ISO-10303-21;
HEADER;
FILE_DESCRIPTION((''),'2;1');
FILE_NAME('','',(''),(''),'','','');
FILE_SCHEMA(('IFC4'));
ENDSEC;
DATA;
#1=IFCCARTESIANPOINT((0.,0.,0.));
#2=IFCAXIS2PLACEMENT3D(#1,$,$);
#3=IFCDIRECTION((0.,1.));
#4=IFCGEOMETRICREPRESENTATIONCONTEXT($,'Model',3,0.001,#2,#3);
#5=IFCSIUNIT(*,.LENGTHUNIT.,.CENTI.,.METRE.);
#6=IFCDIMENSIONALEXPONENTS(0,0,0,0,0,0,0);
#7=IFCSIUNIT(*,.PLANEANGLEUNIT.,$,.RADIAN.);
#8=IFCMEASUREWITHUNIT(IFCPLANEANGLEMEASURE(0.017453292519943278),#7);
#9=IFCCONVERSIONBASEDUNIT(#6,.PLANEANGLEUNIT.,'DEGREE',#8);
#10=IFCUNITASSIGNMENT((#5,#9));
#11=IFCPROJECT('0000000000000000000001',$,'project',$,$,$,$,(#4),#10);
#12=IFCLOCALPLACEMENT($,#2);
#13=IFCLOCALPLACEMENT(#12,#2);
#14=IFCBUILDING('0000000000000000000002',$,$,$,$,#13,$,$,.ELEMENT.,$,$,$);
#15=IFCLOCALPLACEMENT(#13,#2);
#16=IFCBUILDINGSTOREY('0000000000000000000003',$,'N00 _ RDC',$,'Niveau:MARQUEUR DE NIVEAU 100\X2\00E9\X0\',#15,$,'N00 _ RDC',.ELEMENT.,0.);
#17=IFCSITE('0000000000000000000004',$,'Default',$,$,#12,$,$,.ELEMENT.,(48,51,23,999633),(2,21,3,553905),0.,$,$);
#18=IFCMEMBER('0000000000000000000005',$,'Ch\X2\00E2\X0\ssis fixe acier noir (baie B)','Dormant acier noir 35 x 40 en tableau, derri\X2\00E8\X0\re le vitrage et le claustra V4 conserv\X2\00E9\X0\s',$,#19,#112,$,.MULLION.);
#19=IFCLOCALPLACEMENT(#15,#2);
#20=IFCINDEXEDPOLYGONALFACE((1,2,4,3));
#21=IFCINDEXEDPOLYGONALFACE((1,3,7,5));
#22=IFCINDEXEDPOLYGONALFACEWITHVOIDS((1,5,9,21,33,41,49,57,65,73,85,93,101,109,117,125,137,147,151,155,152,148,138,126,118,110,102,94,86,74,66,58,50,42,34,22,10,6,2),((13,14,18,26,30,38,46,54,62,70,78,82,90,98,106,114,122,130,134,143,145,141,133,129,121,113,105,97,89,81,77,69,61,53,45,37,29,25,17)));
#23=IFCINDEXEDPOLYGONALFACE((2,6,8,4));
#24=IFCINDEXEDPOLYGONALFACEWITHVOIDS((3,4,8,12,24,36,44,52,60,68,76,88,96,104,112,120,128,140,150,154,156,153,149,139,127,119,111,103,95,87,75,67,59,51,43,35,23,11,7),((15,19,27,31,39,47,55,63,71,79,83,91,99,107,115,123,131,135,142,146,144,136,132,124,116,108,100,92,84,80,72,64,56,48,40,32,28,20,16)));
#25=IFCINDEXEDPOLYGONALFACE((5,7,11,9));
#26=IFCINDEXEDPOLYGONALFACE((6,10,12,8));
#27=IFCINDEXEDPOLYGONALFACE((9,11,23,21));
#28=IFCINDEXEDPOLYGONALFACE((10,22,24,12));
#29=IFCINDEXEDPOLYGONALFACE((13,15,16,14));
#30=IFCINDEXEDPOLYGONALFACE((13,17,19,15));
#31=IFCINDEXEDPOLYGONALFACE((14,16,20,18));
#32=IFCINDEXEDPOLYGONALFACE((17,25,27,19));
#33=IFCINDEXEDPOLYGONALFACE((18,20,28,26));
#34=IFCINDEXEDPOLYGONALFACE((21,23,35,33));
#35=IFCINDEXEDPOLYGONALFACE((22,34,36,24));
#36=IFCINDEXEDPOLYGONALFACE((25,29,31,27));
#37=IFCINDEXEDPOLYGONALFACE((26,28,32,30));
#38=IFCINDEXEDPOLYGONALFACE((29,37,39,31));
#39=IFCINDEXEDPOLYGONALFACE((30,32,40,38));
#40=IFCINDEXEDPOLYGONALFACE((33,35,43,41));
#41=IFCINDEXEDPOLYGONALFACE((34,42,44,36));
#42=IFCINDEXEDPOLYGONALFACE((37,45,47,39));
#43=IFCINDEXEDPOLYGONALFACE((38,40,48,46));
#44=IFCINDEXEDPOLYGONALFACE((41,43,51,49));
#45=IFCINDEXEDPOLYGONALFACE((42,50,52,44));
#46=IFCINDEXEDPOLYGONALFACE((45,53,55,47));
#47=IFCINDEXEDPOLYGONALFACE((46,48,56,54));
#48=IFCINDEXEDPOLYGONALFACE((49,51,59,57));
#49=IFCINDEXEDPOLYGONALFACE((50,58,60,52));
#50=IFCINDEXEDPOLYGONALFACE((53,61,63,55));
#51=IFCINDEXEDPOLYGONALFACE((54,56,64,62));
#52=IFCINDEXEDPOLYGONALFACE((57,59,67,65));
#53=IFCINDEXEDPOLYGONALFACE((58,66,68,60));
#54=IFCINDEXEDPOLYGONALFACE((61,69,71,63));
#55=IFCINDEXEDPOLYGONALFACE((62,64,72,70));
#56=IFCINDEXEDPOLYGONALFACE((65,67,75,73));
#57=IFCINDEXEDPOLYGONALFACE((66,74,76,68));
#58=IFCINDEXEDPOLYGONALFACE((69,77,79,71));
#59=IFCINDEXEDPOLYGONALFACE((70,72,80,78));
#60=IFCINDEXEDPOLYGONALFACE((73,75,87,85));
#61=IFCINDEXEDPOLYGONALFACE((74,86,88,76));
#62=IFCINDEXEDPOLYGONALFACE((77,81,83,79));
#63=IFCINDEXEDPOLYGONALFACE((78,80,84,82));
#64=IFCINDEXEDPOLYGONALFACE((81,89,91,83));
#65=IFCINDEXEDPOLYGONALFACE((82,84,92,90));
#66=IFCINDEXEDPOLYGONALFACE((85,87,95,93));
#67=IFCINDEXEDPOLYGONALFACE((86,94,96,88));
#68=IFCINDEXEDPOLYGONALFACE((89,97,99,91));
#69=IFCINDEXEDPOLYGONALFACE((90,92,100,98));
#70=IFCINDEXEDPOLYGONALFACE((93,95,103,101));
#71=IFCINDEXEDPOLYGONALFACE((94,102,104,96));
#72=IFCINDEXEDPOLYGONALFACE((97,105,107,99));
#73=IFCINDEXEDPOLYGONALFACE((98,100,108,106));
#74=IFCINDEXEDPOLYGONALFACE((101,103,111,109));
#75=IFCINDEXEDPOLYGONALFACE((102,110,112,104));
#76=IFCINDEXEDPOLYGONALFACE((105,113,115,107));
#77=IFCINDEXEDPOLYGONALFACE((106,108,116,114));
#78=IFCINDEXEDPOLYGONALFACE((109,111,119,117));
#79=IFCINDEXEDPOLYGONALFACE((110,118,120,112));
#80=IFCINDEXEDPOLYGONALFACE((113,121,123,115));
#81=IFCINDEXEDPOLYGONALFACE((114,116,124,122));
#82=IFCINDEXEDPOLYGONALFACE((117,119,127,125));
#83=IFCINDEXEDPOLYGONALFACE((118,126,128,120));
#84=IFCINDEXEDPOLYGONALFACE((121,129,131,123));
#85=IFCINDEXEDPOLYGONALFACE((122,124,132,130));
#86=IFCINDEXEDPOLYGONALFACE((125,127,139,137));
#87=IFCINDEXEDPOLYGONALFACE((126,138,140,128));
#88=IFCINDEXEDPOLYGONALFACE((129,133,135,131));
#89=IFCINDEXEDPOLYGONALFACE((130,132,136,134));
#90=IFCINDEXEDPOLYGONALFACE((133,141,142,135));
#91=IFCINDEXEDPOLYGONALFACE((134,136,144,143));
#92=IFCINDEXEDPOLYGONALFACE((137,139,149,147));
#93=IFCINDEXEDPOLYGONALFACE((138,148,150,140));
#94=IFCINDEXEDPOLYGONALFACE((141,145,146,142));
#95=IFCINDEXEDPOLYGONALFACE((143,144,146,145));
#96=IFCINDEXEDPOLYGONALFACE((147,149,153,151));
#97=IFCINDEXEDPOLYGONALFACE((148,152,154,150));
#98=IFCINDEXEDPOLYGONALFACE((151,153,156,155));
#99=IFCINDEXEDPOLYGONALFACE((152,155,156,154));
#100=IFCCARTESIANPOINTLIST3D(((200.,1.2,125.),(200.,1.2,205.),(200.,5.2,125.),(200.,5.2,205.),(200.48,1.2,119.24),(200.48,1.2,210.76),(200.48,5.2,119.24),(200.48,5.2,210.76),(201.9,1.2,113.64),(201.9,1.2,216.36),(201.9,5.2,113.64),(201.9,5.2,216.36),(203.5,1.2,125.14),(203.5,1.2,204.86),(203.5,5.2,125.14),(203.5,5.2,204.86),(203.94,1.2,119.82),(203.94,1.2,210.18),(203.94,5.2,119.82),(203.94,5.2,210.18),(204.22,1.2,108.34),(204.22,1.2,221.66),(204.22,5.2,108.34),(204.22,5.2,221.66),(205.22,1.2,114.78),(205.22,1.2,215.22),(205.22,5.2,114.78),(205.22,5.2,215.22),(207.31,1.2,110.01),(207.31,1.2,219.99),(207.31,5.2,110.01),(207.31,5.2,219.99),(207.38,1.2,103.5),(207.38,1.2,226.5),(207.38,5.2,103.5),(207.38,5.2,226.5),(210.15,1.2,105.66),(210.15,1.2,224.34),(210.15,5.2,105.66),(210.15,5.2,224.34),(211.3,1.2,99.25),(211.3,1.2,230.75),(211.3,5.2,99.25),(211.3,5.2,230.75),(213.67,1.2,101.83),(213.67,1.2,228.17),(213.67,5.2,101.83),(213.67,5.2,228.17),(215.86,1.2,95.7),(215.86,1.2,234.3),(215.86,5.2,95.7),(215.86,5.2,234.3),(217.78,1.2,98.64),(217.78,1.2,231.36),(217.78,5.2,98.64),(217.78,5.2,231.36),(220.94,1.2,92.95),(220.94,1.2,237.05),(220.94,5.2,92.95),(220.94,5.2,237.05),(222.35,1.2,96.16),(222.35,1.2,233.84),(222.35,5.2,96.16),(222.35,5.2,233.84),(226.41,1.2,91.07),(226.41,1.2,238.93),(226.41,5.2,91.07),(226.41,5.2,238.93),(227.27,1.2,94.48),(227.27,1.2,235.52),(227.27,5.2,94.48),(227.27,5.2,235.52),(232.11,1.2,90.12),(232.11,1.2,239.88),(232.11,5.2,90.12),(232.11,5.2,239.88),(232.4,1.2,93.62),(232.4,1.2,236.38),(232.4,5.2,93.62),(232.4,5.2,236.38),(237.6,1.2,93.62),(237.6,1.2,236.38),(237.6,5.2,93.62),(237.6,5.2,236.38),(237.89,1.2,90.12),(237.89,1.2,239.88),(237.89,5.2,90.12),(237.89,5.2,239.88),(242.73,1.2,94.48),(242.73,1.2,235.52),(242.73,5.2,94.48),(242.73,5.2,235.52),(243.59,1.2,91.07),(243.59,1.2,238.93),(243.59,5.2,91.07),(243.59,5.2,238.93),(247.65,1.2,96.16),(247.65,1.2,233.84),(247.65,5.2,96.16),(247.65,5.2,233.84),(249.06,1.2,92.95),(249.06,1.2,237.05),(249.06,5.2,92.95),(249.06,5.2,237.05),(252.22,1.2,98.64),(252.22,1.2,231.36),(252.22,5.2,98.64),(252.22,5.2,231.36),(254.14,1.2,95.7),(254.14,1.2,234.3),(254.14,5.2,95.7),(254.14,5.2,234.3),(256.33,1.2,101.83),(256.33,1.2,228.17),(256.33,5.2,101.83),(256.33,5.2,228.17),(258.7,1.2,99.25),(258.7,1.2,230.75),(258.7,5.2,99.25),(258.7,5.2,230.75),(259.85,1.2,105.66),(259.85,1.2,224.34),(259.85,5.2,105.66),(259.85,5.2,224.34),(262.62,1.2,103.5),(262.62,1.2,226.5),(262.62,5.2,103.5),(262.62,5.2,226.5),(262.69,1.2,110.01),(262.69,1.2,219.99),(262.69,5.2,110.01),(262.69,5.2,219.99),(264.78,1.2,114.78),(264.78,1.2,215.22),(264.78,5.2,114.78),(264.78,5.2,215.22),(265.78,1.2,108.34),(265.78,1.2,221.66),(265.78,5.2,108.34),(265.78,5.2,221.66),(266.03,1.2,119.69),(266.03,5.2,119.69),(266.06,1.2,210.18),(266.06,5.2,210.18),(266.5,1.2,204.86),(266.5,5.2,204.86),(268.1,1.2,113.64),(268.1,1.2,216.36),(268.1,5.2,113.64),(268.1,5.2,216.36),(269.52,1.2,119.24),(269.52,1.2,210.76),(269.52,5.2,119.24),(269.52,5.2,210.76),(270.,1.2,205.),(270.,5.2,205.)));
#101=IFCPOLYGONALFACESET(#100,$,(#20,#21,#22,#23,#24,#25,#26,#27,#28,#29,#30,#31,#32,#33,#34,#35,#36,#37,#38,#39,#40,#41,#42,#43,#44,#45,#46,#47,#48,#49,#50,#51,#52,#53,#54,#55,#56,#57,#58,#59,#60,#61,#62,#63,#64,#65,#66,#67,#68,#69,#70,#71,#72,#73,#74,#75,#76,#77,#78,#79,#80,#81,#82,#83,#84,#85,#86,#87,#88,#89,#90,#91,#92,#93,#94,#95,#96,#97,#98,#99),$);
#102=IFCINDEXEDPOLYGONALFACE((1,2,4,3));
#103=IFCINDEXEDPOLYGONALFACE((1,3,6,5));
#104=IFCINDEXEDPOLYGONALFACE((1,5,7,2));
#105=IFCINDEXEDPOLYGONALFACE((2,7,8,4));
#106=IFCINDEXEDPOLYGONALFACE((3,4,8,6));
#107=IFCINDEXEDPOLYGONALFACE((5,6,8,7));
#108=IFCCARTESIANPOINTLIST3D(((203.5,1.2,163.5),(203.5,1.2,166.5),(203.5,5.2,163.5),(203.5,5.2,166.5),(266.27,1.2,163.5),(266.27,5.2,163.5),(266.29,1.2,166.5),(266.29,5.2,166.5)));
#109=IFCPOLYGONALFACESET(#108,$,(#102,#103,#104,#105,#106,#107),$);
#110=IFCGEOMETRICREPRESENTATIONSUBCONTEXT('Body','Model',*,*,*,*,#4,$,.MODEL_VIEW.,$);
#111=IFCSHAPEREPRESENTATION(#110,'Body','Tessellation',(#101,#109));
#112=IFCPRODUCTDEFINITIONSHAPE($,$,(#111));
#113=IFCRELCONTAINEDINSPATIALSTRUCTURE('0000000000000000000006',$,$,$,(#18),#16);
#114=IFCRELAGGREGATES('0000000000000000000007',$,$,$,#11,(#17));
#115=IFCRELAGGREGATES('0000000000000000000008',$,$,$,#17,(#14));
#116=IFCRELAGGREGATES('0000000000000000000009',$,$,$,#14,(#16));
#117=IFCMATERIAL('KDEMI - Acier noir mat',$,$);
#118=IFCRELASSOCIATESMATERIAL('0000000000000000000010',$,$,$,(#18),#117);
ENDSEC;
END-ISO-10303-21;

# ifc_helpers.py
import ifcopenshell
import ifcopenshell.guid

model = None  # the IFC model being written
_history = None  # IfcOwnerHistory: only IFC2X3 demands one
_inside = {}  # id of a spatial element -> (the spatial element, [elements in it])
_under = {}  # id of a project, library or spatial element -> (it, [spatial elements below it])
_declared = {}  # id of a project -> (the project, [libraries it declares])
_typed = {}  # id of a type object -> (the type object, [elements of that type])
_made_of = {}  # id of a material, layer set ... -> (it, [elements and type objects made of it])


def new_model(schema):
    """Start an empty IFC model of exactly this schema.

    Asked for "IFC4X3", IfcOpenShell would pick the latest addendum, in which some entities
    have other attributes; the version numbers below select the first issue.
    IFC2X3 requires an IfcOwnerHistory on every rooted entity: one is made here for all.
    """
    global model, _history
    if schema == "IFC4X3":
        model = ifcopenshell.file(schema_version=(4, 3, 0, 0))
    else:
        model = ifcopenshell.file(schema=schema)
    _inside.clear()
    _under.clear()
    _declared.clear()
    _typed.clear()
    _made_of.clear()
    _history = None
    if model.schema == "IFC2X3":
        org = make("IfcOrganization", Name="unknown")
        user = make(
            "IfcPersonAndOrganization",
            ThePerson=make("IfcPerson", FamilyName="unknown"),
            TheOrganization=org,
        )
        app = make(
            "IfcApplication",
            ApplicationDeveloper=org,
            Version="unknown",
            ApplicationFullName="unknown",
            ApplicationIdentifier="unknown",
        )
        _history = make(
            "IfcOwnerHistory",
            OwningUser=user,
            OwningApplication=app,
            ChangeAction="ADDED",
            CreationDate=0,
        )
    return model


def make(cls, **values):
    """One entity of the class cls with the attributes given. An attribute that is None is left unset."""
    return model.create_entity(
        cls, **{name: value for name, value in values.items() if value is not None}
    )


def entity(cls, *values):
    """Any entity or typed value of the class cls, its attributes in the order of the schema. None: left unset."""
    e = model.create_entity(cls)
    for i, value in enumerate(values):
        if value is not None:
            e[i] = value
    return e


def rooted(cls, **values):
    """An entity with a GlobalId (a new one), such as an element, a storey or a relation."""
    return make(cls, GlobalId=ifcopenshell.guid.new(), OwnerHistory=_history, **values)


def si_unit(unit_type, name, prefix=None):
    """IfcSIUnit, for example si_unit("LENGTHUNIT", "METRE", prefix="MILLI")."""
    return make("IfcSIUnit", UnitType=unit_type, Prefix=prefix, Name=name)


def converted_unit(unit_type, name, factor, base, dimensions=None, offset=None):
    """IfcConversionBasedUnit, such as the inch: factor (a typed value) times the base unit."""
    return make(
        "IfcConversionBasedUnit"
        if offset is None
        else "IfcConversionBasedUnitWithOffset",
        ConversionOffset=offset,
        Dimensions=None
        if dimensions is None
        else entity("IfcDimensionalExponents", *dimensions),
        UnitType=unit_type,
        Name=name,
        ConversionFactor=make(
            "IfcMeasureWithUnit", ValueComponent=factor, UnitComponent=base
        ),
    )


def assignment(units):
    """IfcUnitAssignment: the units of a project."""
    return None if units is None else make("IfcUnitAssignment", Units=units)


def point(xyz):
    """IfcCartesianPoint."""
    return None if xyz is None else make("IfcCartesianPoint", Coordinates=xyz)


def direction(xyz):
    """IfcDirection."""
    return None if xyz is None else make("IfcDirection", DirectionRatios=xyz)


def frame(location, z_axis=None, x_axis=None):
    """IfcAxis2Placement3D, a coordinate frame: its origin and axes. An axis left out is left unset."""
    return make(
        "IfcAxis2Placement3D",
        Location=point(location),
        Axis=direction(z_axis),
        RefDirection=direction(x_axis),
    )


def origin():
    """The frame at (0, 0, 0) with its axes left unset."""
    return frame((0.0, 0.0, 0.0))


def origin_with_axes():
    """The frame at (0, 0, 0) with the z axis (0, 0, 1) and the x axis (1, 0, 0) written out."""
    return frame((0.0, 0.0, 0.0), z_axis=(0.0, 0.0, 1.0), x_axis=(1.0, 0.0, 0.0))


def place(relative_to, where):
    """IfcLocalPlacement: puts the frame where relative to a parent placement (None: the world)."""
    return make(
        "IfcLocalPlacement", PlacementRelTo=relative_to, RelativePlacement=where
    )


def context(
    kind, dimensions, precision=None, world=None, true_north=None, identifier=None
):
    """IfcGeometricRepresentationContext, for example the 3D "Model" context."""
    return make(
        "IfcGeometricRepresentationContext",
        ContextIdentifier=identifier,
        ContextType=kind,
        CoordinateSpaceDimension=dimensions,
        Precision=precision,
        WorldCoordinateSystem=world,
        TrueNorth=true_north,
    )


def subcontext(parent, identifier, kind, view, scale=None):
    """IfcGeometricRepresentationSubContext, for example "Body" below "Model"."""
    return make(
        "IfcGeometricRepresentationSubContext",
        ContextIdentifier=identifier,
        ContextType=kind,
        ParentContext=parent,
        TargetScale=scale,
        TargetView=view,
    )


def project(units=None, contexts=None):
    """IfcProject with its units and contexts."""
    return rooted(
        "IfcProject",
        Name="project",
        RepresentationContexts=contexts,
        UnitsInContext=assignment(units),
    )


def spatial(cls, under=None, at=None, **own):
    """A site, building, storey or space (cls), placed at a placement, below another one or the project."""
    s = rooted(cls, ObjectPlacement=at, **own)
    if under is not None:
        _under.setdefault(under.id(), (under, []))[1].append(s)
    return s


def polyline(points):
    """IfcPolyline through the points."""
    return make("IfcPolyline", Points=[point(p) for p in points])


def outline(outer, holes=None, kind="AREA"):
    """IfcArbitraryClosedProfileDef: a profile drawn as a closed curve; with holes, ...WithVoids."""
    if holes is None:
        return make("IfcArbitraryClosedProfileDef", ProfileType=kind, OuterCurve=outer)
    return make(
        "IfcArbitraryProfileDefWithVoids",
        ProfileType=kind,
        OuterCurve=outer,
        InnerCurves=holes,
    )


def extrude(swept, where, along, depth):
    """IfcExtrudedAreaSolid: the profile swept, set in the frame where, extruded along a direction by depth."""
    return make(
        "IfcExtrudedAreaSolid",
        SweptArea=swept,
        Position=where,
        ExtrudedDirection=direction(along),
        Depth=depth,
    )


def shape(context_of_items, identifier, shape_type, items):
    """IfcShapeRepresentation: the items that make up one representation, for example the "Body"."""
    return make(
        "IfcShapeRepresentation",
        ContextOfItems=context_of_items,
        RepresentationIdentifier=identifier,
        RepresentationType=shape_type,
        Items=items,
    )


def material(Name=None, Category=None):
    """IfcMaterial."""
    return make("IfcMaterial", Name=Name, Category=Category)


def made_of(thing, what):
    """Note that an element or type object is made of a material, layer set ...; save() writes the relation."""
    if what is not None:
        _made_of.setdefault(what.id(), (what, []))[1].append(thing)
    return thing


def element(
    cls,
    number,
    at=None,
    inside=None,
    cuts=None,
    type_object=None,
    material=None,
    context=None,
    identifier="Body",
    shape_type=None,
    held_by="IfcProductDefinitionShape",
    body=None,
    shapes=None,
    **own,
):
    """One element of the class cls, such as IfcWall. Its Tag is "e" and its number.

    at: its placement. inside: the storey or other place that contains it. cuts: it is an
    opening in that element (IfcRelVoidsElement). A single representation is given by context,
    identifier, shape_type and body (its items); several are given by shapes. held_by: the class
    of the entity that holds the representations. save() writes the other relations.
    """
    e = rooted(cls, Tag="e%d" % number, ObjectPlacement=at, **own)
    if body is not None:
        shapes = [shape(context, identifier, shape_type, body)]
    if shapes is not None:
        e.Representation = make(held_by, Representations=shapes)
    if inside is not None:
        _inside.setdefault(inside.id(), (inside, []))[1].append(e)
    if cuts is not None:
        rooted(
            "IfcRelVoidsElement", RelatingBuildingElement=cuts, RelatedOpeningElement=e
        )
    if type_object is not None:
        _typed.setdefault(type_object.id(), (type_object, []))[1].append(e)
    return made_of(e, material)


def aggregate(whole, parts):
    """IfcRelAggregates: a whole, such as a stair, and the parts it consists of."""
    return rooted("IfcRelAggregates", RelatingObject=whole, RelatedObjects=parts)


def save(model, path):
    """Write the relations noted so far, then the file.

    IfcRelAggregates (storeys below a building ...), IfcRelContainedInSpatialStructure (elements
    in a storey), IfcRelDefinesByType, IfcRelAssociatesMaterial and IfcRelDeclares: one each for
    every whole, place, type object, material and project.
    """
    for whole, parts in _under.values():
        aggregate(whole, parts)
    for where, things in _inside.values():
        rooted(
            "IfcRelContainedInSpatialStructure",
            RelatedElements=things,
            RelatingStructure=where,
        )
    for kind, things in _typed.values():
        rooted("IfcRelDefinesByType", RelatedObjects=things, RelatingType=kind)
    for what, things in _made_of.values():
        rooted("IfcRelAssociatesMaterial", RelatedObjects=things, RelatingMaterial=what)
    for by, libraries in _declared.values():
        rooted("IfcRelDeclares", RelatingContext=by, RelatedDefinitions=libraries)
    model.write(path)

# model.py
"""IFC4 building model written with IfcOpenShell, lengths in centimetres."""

from ifc_helpers import new_model, entity, si_unit, converted_unit, direction, frame, origin, origin_with_axes, place, context, subcontext, project, spatial, polyline, outline, extrude, material, element, save


model = new_model("IFC4")

# Units and contexts
model_context = context("Model", 3, precision=0.001, world=origin(), true_north=direction((0.0, 1.0)))
body_context = subcontext(model_context, "Body", "Model", "MODEL_VIEW")
ifc_project = project(units=[si_unit("LENGTHUNIT", "METRE", prefix="CENTI"), converted_unit("PLANEANGLEUNIT", "DEGREE", entity("IfcPlaneAngleMeasure", 0.017453292519943278), si_unit("PLANEANGLEUNIT", "RADIAN"), dimensions=[0, 0, 0, 0, 0, 0, 0])], contexts=[model_context])

# Site, building, storey
site_placement = place(None, origin())
site = spatial("IfcSite", under=ifc_project, at=site_placement, Name="Default", CompositionType="ELEMENT", RefLatitude=(48, 51, 23, 999633), RefLongitude=(2, 21, 3, 553905), RefElevation=0.0)
building_placement = place(site_placement, origin())
building = spatial("IfcBuilding", under=site, at=building_placement, CompositionType="ELEMENT")
storey_placement = place(building_placement, origin())
storey = spatial("IfcBuildingStorey", under=building, at=storey_placement, Name="N00 _ RDC", ObjectType="Niveau:MARQUEUR DE NIVEAU 100é", LongName="N00 _ RDC", CompositionType="ELEMENT", Elevation=0.0)

# Member
ifc_material_1 = material(Name="KDEMI - Acier noir mat")
member_1_placement = place(storey_placement, origin_with_axes())
element("IfcMember", 1, at=member_1_placement, inside=storey, material=ifc_material_1, Name="Châssis fixe acier noir (baie B)", Description="Dormant acier noir 35 x 40 en tableau, derrière le vitrage et le claustra V4 conservés", PredefinedType="MULLION", context=body_context, shape_type="SweptSolid", body=[
    extrude(outline(polyline([(269.52, 119.24), (268.1, 113.64), (265.78, 108.34), (262.62, 103.5), (258.7, 99.25), (254.14, 95.7), (249.06, 92.95), (243.59, 91.07), (237.89, 90.12), (232.11, 90.12), (226.41, 91.07), (220.94, 92.95), (215.86, 95.7), (211.3, 99.25), (207.38, 103.5), (204.22, 108.34), (201.9, 113.64), (200.48, 119.24), (200.0, 125.0), (200.0, 205.0), (200.48, 210.76), (201.9, 216.36), (204.22, 221.66), (207.38, 226.5), (211.3, 230.75), (215.86, 234.3), (220.94, 237.05), (226.41, 238.93), (232.11, 239.88), (237.89, 239.88), (243.59, 238.93), (249.06, 237.05), (254.14, 234.3), (258.7, 230.75), (262.62, 226.5), (265.78, 221.66), (268.1, 216.36), (269.52, 210.76), (270.0, 205.0), (269.52, 119.24)]), holes=[polyline([(266.06, 210.18), (264.78, 215.22), (262.69, 219.99), (259.85, 224.34), (256.33, 228.17), (252.22, 231.36), (247.65, 233.84), (242.73, 235.52), (237.6, 236.38), (232.4, 236.38), (227.27, 235.52), (222.35, 233.84), (217.78, 231.36), (213.67, 228.17), (210.15, 224.34), (207.31, 219.99), (205.22, 215.22), (203.94, 210.18), (203.5, 204.86), (203.5, 125.14), (203.94, 119.82), (205.22, 114.78), (207.31, 110.01), (210.15, 105.66), (213.67, 101.83), (217.78, 98.64), (222.35, 96.16), (227.27, 94.48), (232.4, 93.62), (237.6, 93.62), (242.73, 94.48), (247.65, 96.16), (252.22, 98.64), (256.33, 101.83), (259.85, 105.66), (262.69, 110.01), (264.78, 114.78), (266.03, 119.69), (266.5, 204.86), (266.06, 210.18)])]), frame((0.0, 5.2, 0.0), z_axis=(0.0, -1.0, 0.0), x_axis=(1.0, 0.0, 0.0)), (0.0, 0.0, 1.0), 4.0),
    extrude(outline(polyline([(266.29, 166.5), (266.27, 163.5), (203.5, 163.5), (203.5, 166.5), (266.29, 166.5)])), frame((0.0, 5.2, 0.0), z_axis=(0.0, -1.0, 0.0), x_axis=(1.0, 0.0, 0.0)), (0.0, 0.0, 1.0), 4.0),
])

save(model, "model.ifc")
